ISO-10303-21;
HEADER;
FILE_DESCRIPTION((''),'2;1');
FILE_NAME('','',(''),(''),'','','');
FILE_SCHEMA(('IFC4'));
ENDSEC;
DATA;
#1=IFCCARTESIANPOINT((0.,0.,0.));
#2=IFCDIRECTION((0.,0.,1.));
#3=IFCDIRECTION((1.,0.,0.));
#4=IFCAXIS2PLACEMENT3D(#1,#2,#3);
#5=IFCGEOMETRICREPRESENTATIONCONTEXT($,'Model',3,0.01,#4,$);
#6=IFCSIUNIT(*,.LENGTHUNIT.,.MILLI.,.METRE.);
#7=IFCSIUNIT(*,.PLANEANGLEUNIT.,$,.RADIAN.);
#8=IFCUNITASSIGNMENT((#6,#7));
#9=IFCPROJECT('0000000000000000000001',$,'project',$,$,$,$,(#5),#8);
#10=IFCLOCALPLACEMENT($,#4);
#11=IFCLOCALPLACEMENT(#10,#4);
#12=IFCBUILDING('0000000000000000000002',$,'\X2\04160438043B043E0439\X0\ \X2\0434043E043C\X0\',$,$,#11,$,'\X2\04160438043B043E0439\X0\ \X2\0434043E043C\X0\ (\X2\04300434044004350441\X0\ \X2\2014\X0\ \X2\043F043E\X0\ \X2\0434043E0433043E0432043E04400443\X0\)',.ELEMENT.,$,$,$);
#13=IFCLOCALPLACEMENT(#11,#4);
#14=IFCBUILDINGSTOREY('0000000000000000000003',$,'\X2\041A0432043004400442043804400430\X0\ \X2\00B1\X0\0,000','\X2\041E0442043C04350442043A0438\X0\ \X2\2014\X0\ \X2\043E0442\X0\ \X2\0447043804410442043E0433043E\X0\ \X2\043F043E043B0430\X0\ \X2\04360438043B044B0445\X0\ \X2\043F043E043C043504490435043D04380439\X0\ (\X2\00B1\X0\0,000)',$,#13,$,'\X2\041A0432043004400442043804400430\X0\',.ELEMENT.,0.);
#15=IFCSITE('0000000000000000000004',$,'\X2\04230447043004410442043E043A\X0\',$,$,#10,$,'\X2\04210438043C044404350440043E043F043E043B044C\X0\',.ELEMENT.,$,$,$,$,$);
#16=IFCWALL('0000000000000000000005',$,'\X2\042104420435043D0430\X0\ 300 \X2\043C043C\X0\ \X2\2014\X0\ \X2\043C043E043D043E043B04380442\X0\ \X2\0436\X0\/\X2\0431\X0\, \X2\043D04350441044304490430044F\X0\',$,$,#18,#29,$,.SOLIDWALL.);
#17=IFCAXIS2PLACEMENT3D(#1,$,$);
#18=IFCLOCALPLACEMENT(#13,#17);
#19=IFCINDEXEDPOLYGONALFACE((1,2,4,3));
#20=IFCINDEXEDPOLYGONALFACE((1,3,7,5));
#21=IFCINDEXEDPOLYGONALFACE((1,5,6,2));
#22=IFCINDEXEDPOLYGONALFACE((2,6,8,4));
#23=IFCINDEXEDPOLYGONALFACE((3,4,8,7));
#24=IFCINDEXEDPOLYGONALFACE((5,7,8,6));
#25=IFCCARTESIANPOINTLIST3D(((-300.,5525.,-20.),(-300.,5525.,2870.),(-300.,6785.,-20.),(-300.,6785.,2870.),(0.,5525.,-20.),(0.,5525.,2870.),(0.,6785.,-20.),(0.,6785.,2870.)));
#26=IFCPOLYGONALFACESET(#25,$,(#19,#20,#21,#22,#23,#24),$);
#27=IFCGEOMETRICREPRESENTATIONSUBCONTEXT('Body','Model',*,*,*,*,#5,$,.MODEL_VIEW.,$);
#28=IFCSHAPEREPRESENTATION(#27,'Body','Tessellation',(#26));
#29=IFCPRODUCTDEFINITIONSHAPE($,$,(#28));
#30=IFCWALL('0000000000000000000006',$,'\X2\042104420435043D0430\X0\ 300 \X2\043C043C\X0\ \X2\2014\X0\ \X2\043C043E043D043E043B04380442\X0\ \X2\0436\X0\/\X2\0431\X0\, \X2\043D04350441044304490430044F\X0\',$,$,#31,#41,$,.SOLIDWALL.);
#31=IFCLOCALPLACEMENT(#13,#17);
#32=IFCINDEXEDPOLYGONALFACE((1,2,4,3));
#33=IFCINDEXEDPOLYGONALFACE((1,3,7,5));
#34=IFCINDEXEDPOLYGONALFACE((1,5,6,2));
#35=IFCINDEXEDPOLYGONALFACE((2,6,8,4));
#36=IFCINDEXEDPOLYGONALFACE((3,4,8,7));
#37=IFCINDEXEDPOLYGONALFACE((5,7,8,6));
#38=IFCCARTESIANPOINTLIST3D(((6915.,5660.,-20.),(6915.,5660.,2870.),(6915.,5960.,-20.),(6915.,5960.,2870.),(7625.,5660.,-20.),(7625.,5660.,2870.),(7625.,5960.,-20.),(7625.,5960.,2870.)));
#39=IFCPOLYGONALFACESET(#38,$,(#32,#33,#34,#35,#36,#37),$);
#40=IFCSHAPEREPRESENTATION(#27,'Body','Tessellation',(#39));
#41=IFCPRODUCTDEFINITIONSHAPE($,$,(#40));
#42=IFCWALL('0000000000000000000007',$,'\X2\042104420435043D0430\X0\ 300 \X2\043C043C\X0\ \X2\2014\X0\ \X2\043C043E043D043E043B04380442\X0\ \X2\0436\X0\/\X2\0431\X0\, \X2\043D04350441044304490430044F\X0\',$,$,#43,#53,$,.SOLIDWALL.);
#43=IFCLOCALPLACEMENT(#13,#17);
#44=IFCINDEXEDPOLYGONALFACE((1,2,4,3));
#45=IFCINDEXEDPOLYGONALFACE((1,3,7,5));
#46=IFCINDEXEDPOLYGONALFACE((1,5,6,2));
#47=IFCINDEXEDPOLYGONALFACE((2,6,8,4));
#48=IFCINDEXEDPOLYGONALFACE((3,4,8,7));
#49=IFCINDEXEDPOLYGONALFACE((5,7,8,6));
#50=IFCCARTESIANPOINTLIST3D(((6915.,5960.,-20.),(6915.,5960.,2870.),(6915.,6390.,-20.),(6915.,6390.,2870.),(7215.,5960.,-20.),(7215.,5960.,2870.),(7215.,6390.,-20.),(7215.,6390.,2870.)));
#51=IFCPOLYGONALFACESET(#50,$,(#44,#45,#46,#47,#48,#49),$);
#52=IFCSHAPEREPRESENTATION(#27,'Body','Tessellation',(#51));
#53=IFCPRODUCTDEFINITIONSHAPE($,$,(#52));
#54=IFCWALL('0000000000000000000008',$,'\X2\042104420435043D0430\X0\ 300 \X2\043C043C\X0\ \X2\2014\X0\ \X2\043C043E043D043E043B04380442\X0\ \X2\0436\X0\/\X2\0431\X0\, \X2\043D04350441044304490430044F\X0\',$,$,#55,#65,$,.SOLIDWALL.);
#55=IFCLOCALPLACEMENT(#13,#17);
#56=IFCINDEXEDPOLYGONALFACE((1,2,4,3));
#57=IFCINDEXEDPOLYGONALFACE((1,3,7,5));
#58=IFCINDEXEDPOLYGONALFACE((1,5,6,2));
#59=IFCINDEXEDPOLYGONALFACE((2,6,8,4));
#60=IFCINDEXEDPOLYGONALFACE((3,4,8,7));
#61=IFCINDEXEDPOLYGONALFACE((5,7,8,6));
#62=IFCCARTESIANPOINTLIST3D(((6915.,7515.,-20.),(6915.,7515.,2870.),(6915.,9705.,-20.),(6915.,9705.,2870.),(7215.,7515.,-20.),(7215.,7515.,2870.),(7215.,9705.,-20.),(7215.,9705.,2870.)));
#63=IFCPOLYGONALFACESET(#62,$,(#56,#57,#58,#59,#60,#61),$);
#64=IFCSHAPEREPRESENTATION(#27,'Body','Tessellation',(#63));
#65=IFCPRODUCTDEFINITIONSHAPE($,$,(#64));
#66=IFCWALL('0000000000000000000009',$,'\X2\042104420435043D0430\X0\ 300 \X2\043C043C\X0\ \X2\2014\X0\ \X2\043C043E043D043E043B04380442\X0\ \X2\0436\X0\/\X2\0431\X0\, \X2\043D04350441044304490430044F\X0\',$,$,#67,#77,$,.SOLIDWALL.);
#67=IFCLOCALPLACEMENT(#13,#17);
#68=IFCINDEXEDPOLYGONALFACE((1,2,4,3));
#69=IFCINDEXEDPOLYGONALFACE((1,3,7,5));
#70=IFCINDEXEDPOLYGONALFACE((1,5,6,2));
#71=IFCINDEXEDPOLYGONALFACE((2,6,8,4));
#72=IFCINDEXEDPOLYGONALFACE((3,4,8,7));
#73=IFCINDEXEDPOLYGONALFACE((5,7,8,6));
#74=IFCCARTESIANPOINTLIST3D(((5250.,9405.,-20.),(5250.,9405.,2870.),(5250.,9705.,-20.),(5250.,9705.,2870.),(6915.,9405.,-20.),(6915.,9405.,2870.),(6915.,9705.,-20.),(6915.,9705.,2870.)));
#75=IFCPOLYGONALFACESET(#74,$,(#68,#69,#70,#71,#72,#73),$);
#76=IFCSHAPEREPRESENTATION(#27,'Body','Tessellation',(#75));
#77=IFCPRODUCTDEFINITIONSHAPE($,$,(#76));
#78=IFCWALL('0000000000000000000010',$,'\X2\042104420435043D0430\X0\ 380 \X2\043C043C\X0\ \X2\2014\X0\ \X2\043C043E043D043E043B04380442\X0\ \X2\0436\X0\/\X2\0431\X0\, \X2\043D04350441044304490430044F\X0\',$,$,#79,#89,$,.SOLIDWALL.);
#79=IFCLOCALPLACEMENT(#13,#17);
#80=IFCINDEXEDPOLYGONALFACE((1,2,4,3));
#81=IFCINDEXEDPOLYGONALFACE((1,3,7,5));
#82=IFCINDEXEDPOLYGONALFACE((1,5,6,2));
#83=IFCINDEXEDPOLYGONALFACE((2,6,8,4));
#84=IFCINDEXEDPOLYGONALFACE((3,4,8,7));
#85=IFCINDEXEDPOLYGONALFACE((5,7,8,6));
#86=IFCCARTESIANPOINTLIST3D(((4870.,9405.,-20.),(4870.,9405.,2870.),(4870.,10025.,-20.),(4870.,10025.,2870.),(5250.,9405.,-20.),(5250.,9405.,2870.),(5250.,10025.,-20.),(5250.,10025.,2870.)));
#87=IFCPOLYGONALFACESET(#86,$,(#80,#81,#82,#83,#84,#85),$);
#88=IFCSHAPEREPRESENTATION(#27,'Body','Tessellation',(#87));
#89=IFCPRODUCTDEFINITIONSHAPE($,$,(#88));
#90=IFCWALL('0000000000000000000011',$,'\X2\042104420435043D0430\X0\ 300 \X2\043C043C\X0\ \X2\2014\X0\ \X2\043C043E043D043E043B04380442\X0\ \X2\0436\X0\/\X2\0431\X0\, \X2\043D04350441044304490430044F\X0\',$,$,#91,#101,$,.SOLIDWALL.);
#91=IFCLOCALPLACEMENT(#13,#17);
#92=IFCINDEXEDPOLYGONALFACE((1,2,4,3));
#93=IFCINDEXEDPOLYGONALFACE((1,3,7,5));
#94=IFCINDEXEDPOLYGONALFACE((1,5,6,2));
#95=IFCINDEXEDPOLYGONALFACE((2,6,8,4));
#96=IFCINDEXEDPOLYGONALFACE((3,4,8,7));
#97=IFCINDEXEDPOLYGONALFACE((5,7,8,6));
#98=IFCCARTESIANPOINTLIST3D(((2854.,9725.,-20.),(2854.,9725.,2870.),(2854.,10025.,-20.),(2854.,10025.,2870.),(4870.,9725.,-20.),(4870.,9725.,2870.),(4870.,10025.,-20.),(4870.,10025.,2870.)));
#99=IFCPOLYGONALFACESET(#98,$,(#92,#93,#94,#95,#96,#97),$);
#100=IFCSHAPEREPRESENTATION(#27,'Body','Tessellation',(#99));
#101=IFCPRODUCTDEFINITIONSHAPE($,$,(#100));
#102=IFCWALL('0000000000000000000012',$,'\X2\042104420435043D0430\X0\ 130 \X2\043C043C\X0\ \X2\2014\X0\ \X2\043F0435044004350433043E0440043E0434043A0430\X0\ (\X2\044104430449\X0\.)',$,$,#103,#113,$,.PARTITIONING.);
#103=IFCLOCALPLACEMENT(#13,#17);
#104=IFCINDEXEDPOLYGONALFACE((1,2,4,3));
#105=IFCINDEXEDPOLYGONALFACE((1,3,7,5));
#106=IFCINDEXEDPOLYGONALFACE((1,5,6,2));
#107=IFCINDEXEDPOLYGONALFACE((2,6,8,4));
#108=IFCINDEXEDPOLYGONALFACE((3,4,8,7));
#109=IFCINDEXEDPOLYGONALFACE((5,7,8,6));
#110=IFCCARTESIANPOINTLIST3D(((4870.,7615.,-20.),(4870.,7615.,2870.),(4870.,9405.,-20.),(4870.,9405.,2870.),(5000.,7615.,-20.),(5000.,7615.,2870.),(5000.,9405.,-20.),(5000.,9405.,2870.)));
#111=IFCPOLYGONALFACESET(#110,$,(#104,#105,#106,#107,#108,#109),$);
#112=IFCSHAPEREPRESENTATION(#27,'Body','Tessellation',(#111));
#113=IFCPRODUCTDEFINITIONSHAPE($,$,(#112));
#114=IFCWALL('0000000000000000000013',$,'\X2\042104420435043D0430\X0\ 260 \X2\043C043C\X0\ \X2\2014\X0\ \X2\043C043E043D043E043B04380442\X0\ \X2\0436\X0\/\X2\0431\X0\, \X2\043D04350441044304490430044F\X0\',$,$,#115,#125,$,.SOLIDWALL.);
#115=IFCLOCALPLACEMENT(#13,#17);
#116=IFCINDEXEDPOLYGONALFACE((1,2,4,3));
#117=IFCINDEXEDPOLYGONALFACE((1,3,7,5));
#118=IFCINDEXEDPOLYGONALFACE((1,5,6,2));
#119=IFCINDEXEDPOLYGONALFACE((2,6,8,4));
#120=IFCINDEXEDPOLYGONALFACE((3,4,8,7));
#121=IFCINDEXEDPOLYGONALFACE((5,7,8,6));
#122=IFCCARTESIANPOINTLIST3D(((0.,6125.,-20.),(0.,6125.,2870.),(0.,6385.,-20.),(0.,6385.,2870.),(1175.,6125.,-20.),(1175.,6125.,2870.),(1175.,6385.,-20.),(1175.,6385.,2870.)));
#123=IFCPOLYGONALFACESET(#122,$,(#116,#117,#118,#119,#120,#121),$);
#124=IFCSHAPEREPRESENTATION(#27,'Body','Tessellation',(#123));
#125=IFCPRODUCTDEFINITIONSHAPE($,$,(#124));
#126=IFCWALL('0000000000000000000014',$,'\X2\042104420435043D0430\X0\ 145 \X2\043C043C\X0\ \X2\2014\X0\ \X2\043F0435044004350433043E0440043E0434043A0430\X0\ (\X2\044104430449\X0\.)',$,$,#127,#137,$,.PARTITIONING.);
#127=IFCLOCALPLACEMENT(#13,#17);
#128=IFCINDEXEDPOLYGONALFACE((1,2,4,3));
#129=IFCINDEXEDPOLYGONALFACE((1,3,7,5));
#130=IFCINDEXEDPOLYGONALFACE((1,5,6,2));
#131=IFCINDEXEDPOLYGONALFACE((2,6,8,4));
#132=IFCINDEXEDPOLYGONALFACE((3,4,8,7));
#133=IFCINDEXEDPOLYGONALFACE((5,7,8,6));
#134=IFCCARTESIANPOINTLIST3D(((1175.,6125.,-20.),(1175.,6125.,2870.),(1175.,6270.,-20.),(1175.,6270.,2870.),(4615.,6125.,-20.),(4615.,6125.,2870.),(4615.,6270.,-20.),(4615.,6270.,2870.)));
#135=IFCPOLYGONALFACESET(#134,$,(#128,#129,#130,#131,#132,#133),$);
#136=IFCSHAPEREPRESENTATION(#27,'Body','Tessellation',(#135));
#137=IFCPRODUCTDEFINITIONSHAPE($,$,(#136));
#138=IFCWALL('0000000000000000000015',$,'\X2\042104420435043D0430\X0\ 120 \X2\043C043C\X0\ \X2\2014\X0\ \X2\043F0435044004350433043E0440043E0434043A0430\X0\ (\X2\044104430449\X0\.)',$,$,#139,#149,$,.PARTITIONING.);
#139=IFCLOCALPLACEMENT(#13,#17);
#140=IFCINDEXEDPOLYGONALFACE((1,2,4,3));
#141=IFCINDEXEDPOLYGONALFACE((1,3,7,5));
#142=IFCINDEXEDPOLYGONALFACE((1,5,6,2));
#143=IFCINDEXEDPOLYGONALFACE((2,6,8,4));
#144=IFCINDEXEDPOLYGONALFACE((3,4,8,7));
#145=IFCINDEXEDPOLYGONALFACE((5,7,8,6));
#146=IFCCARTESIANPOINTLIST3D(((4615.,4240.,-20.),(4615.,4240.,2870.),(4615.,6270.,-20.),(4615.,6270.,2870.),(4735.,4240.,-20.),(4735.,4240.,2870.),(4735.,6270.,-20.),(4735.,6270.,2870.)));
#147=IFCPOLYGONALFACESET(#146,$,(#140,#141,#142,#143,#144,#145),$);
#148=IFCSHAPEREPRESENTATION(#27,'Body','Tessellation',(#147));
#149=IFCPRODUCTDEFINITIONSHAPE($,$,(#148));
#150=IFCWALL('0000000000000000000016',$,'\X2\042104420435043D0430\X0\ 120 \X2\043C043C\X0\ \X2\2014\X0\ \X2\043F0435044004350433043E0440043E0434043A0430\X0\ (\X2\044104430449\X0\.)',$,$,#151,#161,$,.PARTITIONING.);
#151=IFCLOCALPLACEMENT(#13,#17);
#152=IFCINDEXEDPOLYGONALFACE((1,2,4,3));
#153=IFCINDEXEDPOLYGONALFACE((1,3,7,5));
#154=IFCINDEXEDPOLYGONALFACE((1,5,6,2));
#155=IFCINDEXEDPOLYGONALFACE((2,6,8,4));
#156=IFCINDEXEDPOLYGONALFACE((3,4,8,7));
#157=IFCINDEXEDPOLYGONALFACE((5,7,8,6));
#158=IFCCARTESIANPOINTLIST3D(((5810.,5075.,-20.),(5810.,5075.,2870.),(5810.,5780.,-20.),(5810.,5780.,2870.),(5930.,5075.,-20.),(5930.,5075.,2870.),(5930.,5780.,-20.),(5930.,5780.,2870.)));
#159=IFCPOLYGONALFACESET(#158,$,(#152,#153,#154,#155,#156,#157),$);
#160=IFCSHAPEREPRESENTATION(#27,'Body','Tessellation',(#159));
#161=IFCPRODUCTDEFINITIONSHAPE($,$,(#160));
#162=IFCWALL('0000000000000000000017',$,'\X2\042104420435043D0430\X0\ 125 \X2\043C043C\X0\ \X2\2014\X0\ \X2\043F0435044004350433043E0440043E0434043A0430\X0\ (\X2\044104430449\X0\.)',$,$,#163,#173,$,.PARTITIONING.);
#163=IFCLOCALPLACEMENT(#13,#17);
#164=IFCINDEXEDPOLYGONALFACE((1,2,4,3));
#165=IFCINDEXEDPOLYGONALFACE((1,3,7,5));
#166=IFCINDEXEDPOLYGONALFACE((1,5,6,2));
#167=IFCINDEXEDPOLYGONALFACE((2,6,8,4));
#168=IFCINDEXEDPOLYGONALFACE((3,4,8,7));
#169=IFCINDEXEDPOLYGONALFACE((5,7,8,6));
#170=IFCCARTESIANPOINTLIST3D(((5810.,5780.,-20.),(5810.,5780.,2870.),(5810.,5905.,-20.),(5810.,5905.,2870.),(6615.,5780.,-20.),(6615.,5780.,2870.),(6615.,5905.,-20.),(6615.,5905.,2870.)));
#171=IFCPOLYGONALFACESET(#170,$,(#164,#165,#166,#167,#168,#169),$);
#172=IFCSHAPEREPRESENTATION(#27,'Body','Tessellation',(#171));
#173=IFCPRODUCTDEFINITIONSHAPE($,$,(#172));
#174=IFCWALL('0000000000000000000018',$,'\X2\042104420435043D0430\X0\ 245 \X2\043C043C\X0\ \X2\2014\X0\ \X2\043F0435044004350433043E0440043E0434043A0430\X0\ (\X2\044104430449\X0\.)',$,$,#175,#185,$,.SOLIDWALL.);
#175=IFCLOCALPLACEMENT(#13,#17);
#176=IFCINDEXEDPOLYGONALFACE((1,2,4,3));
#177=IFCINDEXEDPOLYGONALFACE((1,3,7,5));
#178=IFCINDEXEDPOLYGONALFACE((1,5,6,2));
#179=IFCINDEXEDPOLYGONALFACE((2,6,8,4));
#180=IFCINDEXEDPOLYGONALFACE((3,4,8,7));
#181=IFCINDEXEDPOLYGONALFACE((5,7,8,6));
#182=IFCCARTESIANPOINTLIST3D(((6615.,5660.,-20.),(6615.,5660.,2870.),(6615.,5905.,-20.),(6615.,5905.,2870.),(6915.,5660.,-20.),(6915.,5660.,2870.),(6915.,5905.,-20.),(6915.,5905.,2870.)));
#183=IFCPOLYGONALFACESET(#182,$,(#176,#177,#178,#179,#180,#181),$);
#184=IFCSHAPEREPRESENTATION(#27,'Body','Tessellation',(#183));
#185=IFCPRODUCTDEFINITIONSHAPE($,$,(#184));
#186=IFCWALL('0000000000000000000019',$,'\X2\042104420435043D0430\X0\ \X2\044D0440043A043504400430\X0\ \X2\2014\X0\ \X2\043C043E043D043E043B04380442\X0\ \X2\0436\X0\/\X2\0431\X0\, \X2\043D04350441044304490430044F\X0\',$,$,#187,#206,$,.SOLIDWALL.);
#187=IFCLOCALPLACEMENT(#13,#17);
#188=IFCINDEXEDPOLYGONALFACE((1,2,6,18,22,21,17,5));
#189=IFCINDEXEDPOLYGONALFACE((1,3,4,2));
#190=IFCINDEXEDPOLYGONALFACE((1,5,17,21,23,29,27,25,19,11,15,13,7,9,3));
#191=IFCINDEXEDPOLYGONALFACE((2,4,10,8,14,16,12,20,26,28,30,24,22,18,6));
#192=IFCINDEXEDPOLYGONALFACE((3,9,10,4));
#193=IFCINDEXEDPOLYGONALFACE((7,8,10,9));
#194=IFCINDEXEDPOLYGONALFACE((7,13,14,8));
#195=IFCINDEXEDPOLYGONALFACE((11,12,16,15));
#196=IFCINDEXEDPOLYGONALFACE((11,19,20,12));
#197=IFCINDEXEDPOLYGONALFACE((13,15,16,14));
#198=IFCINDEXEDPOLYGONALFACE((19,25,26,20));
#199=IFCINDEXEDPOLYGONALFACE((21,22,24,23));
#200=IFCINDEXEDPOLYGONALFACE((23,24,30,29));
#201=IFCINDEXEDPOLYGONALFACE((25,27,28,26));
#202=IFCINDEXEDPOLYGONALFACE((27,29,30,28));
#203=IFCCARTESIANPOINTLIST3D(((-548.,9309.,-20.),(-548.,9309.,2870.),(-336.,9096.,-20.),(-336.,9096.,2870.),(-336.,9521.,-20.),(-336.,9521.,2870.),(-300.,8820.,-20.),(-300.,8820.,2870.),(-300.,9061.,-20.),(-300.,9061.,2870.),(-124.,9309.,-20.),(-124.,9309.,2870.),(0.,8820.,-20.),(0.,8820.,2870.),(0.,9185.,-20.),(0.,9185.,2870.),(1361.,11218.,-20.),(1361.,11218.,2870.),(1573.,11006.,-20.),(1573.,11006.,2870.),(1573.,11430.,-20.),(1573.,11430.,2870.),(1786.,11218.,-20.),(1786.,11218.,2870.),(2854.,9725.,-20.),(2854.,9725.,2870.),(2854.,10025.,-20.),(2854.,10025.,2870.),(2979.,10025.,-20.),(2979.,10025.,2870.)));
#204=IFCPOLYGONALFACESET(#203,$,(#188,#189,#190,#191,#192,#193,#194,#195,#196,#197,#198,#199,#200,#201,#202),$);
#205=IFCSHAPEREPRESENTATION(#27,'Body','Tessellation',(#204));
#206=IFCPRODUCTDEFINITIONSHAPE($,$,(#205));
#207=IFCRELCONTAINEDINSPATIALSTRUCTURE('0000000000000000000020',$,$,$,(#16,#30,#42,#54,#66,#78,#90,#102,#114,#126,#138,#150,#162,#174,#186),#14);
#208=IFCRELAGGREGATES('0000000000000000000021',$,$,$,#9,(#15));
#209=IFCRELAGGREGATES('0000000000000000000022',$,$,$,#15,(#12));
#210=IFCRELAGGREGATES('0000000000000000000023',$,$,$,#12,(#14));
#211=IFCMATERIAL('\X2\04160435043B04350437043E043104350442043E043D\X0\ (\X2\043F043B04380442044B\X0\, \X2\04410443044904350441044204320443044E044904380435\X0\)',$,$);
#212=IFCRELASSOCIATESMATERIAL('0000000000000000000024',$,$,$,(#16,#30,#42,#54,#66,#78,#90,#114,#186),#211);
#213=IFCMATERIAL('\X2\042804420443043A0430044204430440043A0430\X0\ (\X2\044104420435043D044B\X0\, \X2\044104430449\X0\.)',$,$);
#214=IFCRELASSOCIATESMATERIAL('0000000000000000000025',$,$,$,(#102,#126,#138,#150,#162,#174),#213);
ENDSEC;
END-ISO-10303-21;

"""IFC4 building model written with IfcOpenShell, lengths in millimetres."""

from ifc_helpers import new_model, si_unit, frame, origin, origin_with_axes, place, context, subcontext, project, spatial, polyline, outline, extrude, material, element, save


model = new_model("IFC4")

# Units and contexts
model_context = context("Model", 3, precision=0.01, world=origin_with_axes())
body_context = subcontext(model_context, "Body", "Model", "MODEL_VIEW")
ifc_project = project(units=[si_unit("LENGTHUNIT", "METRE", prefix="MILLI"), si_unit("PLANEANGLEUNIT", "RADIAN")], contexts=[model_context])

# Site, building, storey
site_placement = place(None, origin_with_axes())
site = spatial("IfcSite", under=ifc_project, at=site_placement, Name="Участок", LongName="Симферополь", CompositionType="ELEMENT")
building_placement = place(site_placement, origin_with_axes())
building = spatial("IfcBuilding", under=site, at=building_placement, Name="Жилой дом", LongName="Жилой дом (адрес — по договору)", CompositionType="ELEMENT")
storey_placement = place(building_placement, origin_with_axes())
storey = spatial("IfcBuildingStorey", under=building, at=storey_placement, Name="Квартира ±0,000", Description="Отметки — от чистого пола жилых помещений (±0,000)", LongName="Квартира", CompositionType="ELEMENT", Elevation=0.0)

# Walls
ifc_material_1 = material(Name="Железобетон (плиты, существующие)")
wall_1_placement = place(storey_placement, frame((-300.0, 5525.0, -20.0)))
element("IfcWall", 1, at=wall_1_placement, inside=storey, material=ifc_material_1, Name="Стена 300 мм — монолит ж/б, несущая", PredefinedType="SOLIDWALL", context=body_context, shape_type="SweptSolid", body=[
    extrude(outline(polyline([(0.0, 0.0), (300.0, 0.0), (300.0, 1260.0), (0.0, 1260.0), (0.0, 0.0)])), origin(), (0.0, 0.0, 1.0), 2890.0),
])
wall_2_placement = place(storey_placement, frame((6915.0, 5660.0, -20.0)))
element("IfcWall", 2, at=wall_2_placement, inside=storey, material=ifc_material_1, Name="Стена 300 мм — монолит ж/б, несущая", PredefinedType="SOLIDWALL", context=body_context, shape_type="SweptSolid", body=[
    extrude(outline(polyline([(0.0, 0.0), (710.0, 0.0), (710.0, 300.0), (0.0, 300.0), (0.0, 0.0)])), origin(), (0.0, 0.0, 1.0), 2890.0),
])
wall_3_placement = place(storey_placement, frame((6915.0, 5960.0, -20.0)))
element("IfcWall", 3, at=wall_3_placement, inside=storey, material=ifc_material_1, Name="Стена 300 мм — монолит ж/б, несущая", PredefinedType="SOLIDWALL", context=body_context, shape_type="SweptSolid", body=[
    extrude(outline(polyline([(0.0, 0.0), (300.0, 0.0), (300.0, 430.0), (0.0, 430.0), (0.0, 0.0)])), origin(), (0.0, 0.0, 1.0), 2890.0),
])
wall_4_placement = place(storey_placement, frame((6915.0, 7515.0, -20.0)))
element("IfcWall", 4, at=wall_4_placement, inside=storey, material=ifc_material_1, Name="Стена 300 мм — монолит ж/б, несущая", PredefinedType="SOLIDWALL", context=body_context, shape_type="SweptSolid", body=[
    extrude(outline(polyline([(0.0, 0.0), (300.0, 0.0), (300.0, 2190.0), (0.0, 2190.0), (0.0, 0.0)])), origin(), (0.0, 0.0, 1.0), 2890.0),
])
wall_5_placement = place(storey_placement, frame((5250.0, 9405.0, -20.0)))
element("IfcWall", 5, at=wall_5_placement, inside=storey, material=ifc_material_1, Name="Стена 300 мм — монолит ж/б, несущая", PredefinedType="SOLIDWALL", context=body_context, shape_type="SweptSolid", body=[
    extrude(outline(polyline([(0.0, 0.0), (1665.0, 0.0), (1665.0, 300.0), (0.0, 300.0), (0.0, 0.0)])), origin(), (0.0, 0.0, 1.0), 2890.0),
])
wall_6_placement = place(storey_placement, frame((4870.0, 9405.0, -20.0)))
element("IfcWall", 6, at=wall_6_placement, inside=storey, material=ifc_material_1, Name="Стена 380 мм — монолит ж/б, несущая", PredefinedType="SOLIDWALL", context=body_context, shape_type="SweptSolid", body=[
    extrude(outline(polyline([(0.0, 0.0), (380.0, 0.0), (380.0, 620.0), (0.0, 620.0), (0.0, 0.0)])), origin(), (0.0, 0.0, 1.0), 2890.0),
])
wall_7_placement = place(storey_placement, frame((2854.0, 9725.0, -20.0)))
element("IfcWall", 7, at=wall_7_placement, inside=storey, material=ifc_material_1, Name="Стена 300 мм — монолит ж/б, несущая", PredefinedType="SOLIDWALL", context=body_context, shape_type="SweptSolid", body=[
    extrude(outline(polyline([(0.0, 0.0), (2016.0, 0.0), (2016.0, 300.0), (0.0, 300.0), (0.0, 0.0)])), origin(), (0.0, 0.0, 1.0), 2890.0),
])
ifc_material_2 = material(Name="Штукатурка (стены, сущ.)")
wall_8_placement = place(storey_placement, frame((4870.0, 7615.0, -20.0)))
element("IfcWall", 8, at=wall_8_placement, inside=storey, material=ifc_material_2, Name="Стена 130 мм — перегородка (сущ.)", PredefinedType="PARTITIONING", context=body_context, shape_type="SweptSolid", body=[
    extrude(outline(polyline([(0.0, 0.0), (130.0, 0.0), (130.0, 1790.0), (0.0, 1790.0), (0.0, 0.0)])), origin(), (0.0, 0.0, 1.0), 2890.0),
])
wall_9_placement = place(storey_placement, frame((0.0, 6125.0, -20.0)))
element("IfcWall", 9, at=wall_9_placement, inside=storey, material=ifc_material_1, Name="Стена 260 мм — монолит ж/б, несущая", PredefinedType="SOLIDWALL", context=body_context, shape_type="SweptSolid", body=[
    extrude(outline(polyline([(0.0, 0.0), (1175.0, 0.0), (1175.0, 260.0), (0.0, 260.0), (0.0, 0.0)])), origin(), (0.0, 0.0, 1.0), 2890.0),
])
wall_10_placement = place(storey_placement, frame((1175.0, 6125.0, -20.0)))
element("IfcWall", 10, at=wall_10_placement, inside=storey, material=ifc_material_2, Name="Стена 145 мм — перегородка (сущ.)", PredefinedType="PARTITIONING", context=body_context, shape_type="SweptSolid", body=[
    extrude(outline(polyline([(0.0, 0.0), (3440.0, 0.0), (3440.0, 145.0), (0.0, 145.0), (0.0, 0.0)])), origin(), (0.0, 0.0, 1.0), 2890.0),
])
wall_11_placement = place(storey_placement, frame((4615.0, 4240.0, -20.0)))
element("IfcWall", 11, at=wall_11_placement, inside=storey, material=ifc_material_2, Name="Стена 120 мм — перегородка (сущ.)", PredefinedType="PARTITIONING", context=body_context, shape_type="SweptSolid", body=[
    extrude(outline(polyline([(0.0, 0.0), (120.0, 0.0), (120.0, 2030.0), (0.0, 2030.0), (0.0, 0.0)])), origin(), (0.0, 0.0, 1.0), 2890.0),
])
wall_12_placement = place(storey_placement, frame((5810.0, 5075.0, -20.0)))
element("IfcWall", 12, at=wall_12_placement, inside=storey, material=ifc_material_2, Name="Стена 120 мм — перегородка (сущ.)", PredefinedType="PARTITIONING", context=body_context, shape_type="SweptSolid", body=[
    extrude(outline(polyline([(0.0, 0.0), (120.0, 0.0), (120.0, 705.0), (0.0, 705.0), (0.0, 0.0)])), origin(), (0.0, 0.0, 1.0), 2890.0),
])
wall_13_placement = place(storey_placement, frame((5810.0, 5780.0, -20.0)))
element("IfcWall", 13, at=wall_13_placement, inside=storey, material=ifc_material_2, Name="Стена 125 мм — перегородка (сущ.)", PredefinedType="PARTITIONING", context=body_context, shape_type="SweptSolid", body=[
    extrude(outline(polyline([(0.0, 0.0), (805.0, 0.0), (805.0, 125.0), (0.0, 125.0), (0.0, 0.0)])), origin(), (0.0, 0.0, 1.0), 2890.0),
])
wall_14_placement = place(storey_placement, frame((6615.0, 5660.0, -20.0)))
element("IfcWall", 14, at=wall_14_placement, inside=storey, material=ifc_material_2, Name="Стена 245 мм — перегородка (сущ.)", PredefinedType="SOLIDWALL", context=body_context, shape_type="SweptSolid", body=[
    extrude(outline(polyline([(0.0, 0.0), (300.0, 0.0), (300.0, 245.0), (0.0, 245.0), (0.0, 0.0)])), origin(), (0.0, 0.0, 1.0), 2890.0),
])
wall_15_placement = place(storey_placement, frame((-548.0, 8820.0, -20.0)))
element("IfcWall", 15, at=wall_15_placement, inside=storey, material=ifc_material_1, Name="Стена эркера — монолит ж/б, несущая", PredefinedType="SOLIDWALL", context=body_context, shape_type="SweptSolid", body=[
    extrude(outline(polyline([(248.0, 0.0), (548.0, 0.0), (548.0, 365.0), (424.0, 489.0), (2121.0, 2186.0), (3402.0, 905.0), (3402.0, 1205.0), (3527.0, 1205.0), (2334.0, 2398.0), (2121.0, 2610.0), (1909.0, 2398.0), (212.0, 701.0), (0.0, 489.0), (212.0, 276.0), (248.0, 241.0), (248.0, 0.0)])), origin(), (0.0, 0.0, 1.0), 2890.0),
])

save(model, "model.ifc")
